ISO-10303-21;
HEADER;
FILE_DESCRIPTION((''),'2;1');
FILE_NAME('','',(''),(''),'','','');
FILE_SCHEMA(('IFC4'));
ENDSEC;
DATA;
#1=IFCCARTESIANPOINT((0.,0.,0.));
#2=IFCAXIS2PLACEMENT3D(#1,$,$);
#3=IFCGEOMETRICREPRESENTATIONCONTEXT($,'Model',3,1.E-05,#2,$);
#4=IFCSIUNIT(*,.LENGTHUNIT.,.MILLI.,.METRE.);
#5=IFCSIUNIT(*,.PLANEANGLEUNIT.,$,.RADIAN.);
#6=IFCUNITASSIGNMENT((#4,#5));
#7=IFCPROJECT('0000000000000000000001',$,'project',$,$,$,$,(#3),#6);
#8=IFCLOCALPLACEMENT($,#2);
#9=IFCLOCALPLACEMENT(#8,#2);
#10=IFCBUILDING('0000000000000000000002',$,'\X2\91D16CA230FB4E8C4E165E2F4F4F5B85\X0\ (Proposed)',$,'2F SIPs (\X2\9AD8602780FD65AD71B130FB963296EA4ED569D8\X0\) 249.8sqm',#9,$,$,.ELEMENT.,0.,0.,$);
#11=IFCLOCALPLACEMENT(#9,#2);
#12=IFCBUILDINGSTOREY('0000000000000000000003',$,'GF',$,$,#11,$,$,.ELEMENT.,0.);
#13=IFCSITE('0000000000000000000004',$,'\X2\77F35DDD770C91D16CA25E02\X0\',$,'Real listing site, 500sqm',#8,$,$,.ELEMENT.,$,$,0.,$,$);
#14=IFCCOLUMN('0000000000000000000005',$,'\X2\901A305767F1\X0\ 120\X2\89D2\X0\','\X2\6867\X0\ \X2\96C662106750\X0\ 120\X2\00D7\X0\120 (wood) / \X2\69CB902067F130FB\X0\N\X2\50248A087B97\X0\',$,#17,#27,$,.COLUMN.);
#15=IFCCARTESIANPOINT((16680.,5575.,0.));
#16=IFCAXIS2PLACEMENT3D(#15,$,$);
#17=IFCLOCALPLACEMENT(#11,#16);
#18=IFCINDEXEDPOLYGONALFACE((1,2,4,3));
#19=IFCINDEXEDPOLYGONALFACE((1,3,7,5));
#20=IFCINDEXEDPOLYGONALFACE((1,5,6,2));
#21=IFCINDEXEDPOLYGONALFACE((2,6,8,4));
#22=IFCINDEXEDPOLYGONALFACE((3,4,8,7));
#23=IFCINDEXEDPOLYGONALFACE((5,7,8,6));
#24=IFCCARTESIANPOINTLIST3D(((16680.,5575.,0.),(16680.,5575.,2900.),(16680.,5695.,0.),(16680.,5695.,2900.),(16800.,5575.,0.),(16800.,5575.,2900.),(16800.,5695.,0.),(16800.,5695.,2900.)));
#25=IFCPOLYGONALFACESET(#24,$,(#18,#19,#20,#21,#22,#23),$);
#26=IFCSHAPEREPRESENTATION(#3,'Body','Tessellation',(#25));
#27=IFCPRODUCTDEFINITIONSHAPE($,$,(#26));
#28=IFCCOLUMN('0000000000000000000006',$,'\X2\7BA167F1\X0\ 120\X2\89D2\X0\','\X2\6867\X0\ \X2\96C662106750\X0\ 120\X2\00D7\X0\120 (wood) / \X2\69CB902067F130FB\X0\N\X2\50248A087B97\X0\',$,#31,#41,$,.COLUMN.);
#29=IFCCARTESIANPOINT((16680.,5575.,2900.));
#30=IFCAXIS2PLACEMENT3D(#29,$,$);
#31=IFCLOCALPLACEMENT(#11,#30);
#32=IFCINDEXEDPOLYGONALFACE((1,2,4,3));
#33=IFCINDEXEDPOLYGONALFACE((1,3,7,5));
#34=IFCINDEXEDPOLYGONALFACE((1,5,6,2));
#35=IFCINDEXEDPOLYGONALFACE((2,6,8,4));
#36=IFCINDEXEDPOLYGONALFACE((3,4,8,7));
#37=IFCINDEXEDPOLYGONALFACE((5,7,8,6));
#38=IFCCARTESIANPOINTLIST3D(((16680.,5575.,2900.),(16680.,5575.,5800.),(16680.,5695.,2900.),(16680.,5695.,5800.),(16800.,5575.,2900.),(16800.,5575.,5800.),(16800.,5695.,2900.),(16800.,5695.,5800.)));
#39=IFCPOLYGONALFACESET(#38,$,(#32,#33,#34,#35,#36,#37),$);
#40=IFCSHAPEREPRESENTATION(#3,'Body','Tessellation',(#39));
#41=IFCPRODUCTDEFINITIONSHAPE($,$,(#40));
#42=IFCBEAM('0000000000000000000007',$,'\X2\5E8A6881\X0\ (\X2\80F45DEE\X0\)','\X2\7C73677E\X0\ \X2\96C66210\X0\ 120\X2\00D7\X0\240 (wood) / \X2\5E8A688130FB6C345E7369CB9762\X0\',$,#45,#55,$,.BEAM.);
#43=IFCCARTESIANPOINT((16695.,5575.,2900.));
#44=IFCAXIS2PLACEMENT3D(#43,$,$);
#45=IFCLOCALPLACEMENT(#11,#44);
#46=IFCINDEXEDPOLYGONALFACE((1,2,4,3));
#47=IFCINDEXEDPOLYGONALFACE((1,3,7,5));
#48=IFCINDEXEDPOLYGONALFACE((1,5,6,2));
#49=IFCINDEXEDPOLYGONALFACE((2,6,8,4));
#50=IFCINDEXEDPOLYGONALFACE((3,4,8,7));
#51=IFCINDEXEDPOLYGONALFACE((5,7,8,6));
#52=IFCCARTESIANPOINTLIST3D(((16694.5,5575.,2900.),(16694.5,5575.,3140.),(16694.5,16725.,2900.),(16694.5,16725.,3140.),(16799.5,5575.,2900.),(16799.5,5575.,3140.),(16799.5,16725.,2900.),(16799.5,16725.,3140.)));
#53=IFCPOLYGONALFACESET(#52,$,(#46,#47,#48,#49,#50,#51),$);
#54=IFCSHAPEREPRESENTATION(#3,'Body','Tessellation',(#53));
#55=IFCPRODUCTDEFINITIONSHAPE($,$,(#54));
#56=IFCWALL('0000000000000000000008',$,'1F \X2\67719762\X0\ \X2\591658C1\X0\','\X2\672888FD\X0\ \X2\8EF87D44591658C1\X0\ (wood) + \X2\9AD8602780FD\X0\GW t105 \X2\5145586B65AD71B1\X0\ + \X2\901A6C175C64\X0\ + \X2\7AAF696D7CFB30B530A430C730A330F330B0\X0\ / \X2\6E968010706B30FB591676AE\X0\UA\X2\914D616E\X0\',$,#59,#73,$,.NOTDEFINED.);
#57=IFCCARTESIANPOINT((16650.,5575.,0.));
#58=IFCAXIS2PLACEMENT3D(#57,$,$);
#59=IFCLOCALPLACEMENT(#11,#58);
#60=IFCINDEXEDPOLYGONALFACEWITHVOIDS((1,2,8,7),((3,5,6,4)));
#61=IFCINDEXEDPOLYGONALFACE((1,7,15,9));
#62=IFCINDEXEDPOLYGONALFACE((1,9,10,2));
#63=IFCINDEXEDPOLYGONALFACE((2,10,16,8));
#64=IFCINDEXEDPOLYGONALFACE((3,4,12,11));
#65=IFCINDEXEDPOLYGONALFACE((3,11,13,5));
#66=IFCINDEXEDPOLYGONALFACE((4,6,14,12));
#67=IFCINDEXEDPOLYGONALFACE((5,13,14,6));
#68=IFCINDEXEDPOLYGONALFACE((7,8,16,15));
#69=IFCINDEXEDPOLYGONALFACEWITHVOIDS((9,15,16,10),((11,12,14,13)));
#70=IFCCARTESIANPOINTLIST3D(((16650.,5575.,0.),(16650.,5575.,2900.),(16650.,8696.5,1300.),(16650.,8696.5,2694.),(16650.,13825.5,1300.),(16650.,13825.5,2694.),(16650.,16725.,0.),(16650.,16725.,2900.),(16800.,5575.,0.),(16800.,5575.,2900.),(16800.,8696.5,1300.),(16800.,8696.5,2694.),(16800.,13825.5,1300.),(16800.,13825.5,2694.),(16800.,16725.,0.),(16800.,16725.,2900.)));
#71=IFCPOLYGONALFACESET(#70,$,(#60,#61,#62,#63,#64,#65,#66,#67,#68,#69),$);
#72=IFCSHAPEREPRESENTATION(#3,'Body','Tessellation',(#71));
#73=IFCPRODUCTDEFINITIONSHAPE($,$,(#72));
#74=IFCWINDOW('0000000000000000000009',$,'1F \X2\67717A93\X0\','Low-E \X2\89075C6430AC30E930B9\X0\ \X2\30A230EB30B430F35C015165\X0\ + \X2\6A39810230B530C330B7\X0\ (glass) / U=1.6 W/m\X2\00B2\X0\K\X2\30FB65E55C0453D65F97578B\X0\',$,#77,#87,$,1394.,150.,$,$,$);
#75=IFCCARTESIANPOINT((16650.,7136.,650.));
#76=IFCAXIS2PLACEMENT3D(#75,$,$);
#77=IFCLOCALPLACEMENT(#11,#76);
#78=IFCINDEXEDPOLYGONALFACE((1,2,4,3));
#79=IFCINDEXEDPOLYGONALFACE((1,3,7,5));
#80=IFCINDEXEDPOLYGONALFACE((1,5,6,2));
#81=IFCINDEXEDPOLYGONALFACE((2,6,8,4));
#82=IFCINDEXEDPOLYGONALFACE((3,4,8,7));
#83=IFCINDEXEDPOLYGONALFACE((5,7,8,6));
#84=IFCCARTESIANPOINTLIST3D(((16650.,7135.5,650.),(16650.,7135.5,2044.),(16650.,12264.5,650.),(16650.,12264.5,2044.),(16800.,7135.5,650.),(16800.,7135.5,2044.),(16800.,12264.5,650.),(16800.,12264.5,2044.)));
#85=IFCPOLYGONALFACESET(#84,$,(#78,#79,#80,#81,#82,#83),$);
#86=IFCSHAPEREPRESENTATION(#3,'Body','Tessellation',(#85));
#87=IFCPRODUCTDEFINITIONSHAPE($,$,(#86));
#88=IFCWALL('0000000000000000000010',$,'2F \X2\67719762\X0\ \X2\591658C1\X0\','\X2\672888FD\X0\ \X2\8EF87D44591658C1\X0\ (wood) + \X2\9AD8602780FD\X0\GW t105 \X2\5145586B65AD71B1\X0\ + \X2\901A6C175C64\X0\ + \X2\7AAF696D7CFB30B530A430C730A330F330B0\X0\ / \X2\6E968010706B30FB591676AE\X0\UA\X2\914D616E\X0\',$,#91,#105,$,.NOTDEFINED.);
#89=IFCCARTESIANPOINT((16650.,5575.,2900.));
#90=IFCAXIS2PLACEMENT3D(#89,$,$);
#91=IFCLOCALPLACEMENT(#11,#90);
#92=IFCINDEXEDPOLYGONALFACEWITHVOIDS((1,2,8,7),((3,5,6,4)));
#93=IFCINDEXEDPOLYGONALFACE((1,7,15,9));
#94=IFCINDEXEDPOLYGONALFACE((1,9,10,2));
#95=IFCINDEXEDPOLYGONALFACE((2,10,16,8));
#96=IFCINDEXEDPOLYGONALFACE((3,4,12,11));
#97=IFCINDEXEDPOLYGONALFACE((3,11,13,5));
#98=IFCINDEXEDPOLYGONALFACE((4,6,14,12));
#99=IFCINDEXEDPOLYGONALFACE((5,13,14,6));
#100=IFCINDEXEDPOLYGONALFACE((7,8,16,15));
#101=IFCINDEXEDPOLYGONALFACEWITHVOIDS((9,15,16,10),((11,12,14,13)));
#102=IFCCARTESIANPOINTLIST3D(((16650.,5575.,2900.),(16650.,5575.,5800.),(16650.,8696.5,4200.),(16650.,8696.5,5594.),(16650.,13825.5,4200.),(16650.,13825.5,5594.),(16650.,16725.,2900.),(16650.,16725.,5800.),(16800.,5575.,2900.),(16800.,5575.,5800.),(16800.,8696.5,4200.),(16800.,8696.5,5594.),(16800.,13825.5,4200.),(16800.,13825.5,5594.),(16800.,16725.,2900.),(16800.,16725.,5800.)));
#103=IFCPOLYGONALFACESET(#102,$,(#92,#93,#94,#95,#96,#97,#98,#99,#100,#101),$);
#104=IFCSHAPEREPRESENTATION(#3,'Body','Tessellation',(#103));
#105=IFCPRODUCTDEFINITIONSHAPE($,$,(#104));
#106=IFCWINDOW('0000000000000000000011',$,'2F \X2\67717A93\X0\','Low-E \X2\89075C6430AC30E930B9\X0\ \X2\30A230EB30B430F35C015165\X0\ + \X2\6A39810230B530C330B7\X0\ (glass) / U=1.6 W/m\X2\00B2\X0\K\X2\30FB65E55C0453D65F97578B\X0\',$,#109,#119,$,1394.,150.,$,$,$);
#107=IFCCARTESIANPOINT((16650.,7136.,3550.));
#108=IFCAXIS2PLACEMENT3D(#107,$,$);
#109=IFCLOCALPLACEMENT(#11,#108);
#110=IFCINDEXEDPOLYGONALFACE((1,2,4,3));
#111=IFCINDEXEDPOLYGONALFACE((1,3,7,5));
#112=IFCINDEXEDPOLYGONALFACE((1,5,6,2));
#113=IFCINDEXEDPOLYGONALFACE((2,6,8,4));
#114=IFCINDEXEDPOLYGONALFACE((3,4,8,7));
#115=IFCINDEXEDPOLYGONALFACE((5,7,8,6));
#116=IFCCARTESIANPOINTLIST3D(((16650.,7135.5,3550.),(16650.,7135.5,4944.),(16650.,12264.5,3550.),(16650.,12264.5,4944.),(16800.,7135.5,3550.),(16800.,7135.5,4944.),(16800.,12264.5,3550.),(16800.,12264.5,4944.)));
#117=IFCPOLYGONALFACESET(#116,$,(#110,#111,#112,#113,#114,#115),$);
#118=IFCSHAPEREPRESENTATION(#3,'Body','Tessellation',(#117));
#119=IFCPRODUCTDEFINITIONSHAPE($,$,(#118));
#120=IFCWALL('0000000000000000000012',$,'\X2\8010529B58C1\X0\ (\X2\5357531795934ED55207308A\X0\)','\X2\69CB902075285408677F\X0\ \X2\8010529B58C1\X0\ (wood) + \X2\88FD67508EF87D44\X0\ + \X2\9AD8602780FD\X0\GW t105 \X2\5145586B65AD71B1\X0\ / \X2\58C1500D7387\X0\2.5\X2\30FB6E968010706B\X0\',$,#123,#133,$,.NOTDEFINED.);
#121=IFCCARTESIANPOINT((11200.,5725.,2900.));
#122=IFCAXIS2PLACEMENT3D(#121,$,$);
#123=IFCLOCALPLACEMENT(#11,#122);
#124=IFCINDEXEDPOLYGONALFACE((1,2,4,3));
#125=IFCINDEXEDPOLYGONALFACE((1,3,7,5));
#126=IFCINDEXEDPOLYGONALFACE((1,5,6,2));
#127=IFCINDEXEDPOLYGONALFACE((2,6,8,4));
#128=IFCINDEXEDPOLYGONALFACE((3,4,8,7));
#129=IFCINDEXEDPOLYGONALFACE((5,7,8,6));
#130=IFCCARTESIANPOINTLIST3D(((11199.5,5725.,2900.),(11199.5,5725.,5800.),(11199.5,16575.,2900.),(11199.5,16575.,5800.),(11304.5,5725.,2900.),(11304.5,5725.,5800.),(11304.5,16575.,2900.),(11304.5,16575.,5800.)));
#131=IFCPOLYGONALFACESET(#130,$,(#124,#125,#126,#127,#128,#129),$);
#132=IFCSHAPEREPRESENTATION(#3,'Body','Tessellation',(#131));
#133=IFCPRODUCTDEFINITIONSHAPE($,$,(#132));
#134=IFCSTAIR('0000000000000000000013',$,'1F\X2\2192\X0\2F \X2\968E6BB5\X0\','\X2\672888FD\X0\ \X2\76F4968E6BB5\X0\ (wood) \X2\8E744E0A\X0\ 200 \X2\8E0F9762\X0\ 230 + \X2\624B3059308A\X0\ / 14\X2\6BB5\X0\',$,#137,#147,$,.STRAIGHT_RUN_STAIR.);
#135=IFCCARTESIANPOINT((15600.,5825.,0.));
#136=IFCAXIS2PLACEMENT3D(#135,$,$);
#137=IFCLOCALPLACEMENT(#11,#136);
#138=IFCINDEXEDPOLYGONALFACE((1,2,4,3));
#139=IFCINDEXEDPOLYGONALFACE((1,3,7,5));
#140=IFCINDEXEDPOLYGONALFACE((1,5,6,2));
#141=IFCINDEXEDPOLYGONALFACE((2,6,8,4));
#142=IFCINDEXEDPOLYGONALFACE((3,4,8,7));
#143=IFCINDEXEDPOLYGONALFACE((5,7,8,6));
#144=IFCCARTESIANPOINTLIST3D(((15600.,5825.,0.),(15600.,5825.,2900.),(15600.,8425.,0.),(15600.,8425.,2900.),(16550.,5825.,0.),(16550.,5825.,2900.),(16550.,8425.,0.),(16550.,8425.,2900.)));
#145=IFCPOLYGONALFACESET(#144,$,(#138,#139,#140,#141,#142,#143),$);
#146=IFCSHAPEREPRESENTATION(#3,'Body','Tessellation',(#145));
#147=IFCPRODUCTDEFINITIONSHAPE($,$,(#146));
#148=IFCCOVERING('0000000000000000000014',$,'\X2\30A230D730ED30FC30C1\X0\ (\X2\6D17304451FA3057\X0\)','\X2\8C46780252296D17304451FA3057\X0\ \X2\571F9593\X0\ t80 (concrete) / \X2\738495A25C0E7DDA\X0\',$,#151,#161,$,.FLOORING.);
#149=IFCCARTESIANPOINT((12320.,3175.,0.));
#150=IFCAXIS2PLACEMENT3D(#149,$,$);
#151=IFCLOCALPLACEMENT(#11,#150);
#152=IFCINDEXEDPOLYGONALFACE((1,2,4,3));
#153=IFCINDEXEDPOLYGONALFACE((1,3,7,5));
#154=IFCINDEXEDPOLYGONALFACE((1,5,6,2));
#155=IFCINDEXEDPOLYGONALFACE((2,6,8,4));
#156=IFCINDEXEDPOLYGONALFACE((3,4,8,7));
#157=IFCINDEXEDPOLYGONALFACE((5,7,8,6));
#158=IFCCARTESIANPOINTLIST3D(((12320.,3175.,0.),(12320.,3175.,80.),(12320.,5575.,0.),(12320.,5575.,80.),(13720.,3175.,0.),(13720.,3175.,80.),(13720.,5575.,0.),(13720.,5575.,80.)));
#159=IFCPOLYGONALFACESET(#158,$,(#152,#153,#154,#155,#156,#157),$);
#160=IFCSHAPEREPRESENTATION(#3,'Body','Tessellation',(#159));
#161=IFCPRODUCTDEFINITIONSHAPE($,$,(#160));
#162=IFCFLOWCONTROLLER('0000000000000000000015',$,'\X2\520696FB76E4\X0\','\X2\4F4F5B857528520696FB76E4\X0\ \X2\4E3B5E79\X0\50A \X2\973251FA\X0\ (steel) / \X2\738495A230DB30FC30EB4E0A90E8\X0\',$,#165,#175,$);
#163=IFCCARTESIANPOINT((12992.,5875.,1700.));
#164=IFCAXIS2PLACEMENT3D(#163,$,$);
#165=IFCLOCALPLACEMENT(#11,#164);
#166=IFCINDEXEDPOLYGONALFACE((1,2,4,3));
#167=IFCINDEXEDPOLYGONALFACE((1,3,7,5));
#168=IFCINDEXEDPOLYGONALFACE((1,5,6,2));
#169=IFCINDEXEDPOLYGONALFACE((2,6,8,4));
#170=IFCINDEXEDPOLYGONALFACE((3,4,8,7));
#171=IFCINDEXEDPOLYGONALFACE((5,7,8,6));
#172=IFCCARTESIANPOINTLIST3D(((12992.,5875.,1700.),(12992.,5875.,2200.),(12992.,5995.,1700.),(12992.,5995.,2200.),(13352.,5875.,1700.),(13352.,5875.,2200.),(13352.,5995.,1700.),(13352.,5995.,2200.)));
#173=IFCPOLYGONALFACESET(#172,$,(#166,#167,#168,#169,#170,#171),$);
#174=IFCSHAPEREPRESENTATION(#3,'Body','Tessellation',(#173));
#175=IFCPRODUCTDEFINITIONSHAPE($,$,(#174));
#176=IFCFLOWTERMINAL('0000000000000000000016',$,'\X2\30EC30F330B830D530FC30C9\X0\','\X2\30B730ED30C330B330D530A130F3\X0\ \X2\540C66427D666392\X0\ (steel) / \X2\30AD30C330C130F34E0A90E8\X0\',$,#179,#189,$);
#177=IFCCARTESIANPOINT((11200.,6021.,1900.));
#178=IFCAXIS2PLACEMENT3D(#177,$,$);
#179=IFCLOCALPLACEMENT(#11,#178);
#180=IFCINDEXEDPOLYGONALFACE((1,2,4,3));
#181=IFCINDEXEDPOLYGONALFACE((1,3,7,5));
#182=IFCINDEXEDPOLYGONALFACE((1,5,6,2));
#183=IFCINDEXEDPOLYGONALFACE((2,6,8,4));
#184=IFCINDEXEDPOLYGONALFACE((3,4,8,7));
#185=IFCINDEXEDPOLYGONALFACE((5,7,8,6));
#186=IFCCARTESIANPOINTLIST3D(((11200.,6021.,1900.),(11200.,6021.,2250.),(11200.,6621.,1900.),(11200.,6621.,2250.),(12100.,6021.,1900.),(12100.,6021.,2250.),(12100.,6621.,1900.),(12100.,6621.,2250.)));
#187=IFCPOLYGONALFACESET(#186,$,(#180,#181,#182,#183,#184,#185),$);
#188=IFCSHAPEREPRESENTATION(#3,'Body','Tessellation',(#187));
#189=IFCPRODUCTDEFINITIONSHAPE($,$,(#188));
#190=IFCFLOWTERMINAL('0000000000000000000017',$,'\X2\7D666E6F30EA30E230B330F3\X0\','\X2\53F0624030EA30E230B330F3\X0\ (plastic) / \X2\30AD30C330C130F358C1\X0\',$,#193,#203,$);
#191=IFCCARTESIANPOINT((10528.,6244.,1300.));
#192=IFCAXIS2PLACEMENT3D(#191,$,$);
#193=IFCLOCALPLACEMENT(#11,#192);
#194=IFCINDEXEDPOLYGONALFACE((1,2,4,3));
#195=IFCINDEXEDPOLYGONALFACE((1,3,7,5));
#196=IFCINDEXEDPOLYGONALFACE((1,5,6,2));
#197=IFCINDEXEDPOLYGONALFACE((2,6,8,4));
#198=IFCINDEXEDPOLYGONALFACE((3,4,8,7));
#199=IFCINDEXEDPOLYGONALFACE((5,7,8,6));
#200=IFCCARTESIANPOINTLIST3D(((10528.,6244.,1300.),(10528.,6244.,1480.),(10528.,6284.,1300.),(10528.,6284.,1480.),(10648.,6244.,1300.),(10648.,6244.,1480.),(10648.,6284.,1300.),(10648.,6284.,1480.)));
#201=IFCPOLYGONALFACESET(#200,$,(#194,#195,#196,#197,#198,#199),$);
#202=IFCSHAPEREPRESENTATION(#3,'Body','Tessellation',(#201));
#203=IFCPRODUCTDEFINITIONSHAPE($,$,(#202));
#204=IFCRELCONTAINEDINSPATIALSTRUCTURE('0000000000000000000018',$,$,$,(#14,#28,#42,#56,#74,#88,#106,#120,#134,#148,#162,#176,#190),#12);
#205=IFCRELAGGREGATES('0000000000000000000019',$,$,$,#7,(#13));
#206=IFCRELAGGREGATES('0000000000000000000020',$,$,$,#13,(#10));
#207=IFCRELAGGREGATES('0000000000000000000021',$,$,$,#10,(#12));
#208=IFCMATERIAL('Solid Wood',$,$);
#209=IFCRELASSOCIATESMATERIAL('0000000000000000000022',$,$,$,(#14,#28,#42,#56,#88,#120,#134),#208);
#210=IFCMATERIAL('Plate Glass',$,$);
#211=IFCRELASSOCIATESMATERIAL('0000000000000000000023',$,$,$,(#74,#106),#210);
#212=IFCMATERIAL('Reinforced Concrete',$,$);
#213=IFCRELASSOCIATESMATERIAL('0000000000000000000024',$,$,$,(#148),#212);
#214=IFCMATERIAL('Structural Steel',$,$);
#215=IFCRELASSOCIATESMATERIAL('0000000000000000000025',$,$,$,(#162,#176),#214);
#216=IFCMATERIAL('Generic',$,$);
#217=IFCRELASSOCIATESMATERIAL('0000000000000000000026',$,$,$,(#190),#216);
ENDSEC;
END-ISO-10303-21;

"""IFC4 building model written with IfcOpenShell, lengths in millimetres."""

from ifc_helpers import new_model, si_unit, frame, frame_2d, origin, place, context, project, spatial, rectangle, extrude, material, element, fill, save


model = new_model("IFC4")

# Units and contexts
model_context = context("Model", 3, precision=1e-05, world=origin())
ifc_project = project(units=[si_unit("LENGTHUNIT", "METRE", prefix="MILLI"), si_unit("PLANEANGLEUNIT", "RADIAN")], contexts=[model_context])

# Site, building, storey
site_placement = place(None, origin())
site = spatial("IfcSite", under=ifc_project, at=site_placement, Name="石川県金沢市", ObjectType="Real listing site, 500sqm", CompositionType="ELEMENT", RefElevation=0.0)
building_placement = place(site_placement, origin())
building = spatial("IfcBuilding", under=site, at=building_placement, Name="金沢・二世帯住宅 (Proposed)", ObjectType="2F SIPs (高性能断熱・防雪仕様) 249.8sqm", CompositionType="ELEMENT", ElevationOfRefHeight=0.0, ElevationOfTerrain=0.0)
storey_placement = place(building_placement, origin())
storey = spatial("IfcBuildingStorey", under=building, at=storey_placement, Name="GF", CompositionType="ELEMENT", Elevation=0.0)

# Columns
ifc_material_1 = material(Name="Solid Wood")
column_1_placement = place(storey_placement, frame((16680.0, 5575.0, 0.0)))
element("IfcColumn", 1, at=column_1_placement, inside=storey, material=ifc_material_1, Name="通し柱 120角", Description="桧 集成材 120×120 (wood) / 構造柱・N値計算", PredefinedType="COLUMN", context=model_context, shape_type="SweptSolid", body=[
    extrude(rectangle(XDim=120.0, YDim=120.0, at=frame_2d((60.0, 60.0))), frame((16680.0, 5575.0, 0.0)), (0.0, 0.0, 1.0), 2900.0),
])
column_2_placement = place(storey_placement, frame((16680.0, 5575.0, 2900.0)))
element("IfcColumn", 2, at=column_2_placement, inside=storey, material=ifc_material_1, Name="管柱 120角", Description="桧 集成材 120×120 (wood) / 構造柱・N値計算", PredefinedType="COLUMN", context=model_context, shape_type="SweptSolid", body=[
    extrude(rectangle(XDim=120.0, YDim=120.0, at=frame_2d((60.0, 60.0))), frame((16680.0, 5575.0, 2900.0)), (0.0, 0.0, 1.0), 2900.0),
])

# Beam
beam_1_placement = place(storey_placement, frame((16695.0, 5575.0, 2900.0)))
element("IfcBeam", 3, at=beam_1_placement, inside=storey, material=ifc_material_1, Name="床梁 (胴差)", Description="米松 集成 120×240 (wood) / 床梁・水平構面", PredefinedType="BEAM", context=model_context, shape_type="SweptSolid", body=[
    extrude(rectangle(XDim=105.0, YDim=11150.0, at=frame_2d((52.0, 5575.0))), frame((16695.0, 5575.0, 2900.0)), (0.0, 0.0, 1.0), 240.0),
])

# Wall, opening, window
wall_1_placement = place(storey_placement, frame((16650.0, 5575.0, 0.0)))
wall_1 = element("IfcWall", 4, at=wall_1_placement, inside=storey, material=ifc_material_1, Name="1F 東面 外壁", Description="木製 軸組外壁 (wood) + 高性能GW t105 充填断熱 + 通気層 + 窯業系サイディング / 準耐火・外皮UA配慮", PredefinedType="NOTDEFINED", context=model_context, shape_type="SweptSolid", body=[
    extrude(rectangle(XDim=150.0, YDim=11150.0, at=frame_2d((75.0, 5575.0))), frame((16650.0, 5575.0, 0.0)), (0.0, 0.0, 1.0), 2900.0),
])
opening_1_placement = place(storey_placement, frame((16650.0, 7136.0, 650.0)))
opening_1 = element("IfcOpeningElement", 5, at=opening_1_placement, cuts=wall_1, PredefinedType="NOTDEFINED", context=model_context, shape_type="SweptSolid", body=[
    extrude(rectangle(XDim=150.0, YDim=5129.0, at=frame_2d((75.0, 2564.0))), frame((16650.0, 7136.0, 650.0)), (0.0, 0.0, 1.0), 1394.0),
])
ifc_material_2 = material(Name="Plate Glass")
window_1_placement = place(storey_placement, frame((16650.0, 7136.0, 650.0)))
window_1 = element("IfcWindow", 6, at=window_1_placement, inside=storey, material=ifc_material_2, Name="1F 東窓", Description="Low-E 複層ガラス アルゴン封入 + 樹脂サッシ (glass) / U=1.6 W/m²K・日射取得型", OverallHeight=1394.0, OverallWidth=150.0, context=model_context, shape_type="SweptSolid", body=[
    extrude(rectangle(XDim=150.0, YDim=5129.0, at=frame_2d((75.0, 2564.0))), frame((16650.0, 7136.0, 650.0)), (0.0, 0.0, 1.0), 1394.0),
])
fill(opening_1, window_1)

# Wall, opening, window
wall_2_placement = place(storey_placement, frame((16650.0, 5575.0, 2900.0)))
wall_2 = element("IfcWall", 7, at=wall_2_placement, inside=storey, material=ifc_material_1, Name="2F 東面 外壁", Description="木製 軸組外壁 (wood) + 高性能GW t105 充填断熱 + 通気層 + 窯業系サイディング / 準耐火・外皮UA配慮", PredefinedType="NOTDEFINED", context=model_context, shape_type="SweptSolid", body=[
    extrude(rectangle(XDim=150.0, YDim=11150.0, at=frame_2d((75.0, 5575.0))), frame((16650.0, 5575.0, 2900.0)), (0.0, 0.0, 1.0), 2900.0),
])
opening_2_placement = place(storey_placement, frame((16650.0, 7136.0, 3550.0)))
opening_2 = element("IfcOpeningElement", 8, at=opening_2_placement, cuts=wall_2, PredefinedType="NOTDEFINED", context=model_context, shape_type="SweptSolid", body=[
    extrude(rectangle(XDim=150.0, YDim=5129.0, at=frame_2d((75.0, 2564.0))), frame((16650.0, 7136.0, 3550.0)), (0.0, 0.0, 1.0), 1394.0),
])
window_2_placement = place(storey_placement, frame((16650.0, 7136.0, 3550.0)))
window_2 = element("IfcWindow", 9, at=window_2_placement, inside=storey, material=ifc_material_2, Name="2F 東窓", Description="Low-E 複層ガラス アルゴン封入 + 樹脂サッシ (glass) / U=1.6 W/m²K・日射取得型", OverallHeight=1394.0, OverallWidth=150.0, context=model_context, shape_type="SweptSolid", body=[
    extrude(rectangle(XDim=150.0, YDim=5129.0, at=frame_2d((75.0, 2564.0))), frame((16650.0, 7136.0, 3550.0)), (0.0, 0.0, 1.0), 1394.0),
])
fill(opening_2, window_2)

# Wall
wall_3_placement = place(storey_placement, frame((11200.0, 5725.0, 2900.0)))
element("IfcWall", 10, at=wall_3_placement, inside=storey, material=ifc_material_1, Name="耐力壁 (南北間仕切り)", Description="構造用合板 耐力壁 (wood) + 製材軸組 + 高性能GW t105 充填断熱 / 壁倍率2.5・準耐火", PredefinedType="NOTDEFINED", context=model_context, shape_type="SweptSolid", body=[
    extrude(rectangle(XDim=105.0, YDim=10850.0, at=frame_2d((52.0, 5425.0))), frame((11200.0, 5725.0, 2900.0)), (0.0, 0.0, 1.0), 2900.0),
])

# Stair
stair_placement = place(storey_placement, frame((15600.0, 5825.0, 0.0)))
element("IfcStair", 11, at=stair_placement, inside=storey, material=ifc_material_1, Name="1F→2F 階段", Description="木製 直階段 (wood) 蹴上 200 踏面 230 + 手すり / 14段", PredefinedType="STRAIGHT_RUN_STAIR", context=model_context, shape_type="SweptSolid", body=[
    extrude(rectangle(XDim=950.0, YDim=2600.0, at=frame_2d((475.0, 1300.0))), frame((15600.0, 5825.0, 0.0)), (0.0, 0.0, 1.0), 2900.0),
])

# Covering
ifc_material_3 = material(Name="Reinforced Concrete")
covering_placement = place(storey_placement, frame((12320.0, 3175.0, 0.0)))
element("IfcCovering", 12, at=covering_placement, inside=storey, material=ifc_material_3, Name="アプローチ (洗い出し)", Description="豆砂利洗い出し 土間 t80 (concrete) / 玄関導線", PredefinedType="FLOORING", context=model_context, shape_type="SweptSolid", body=[
    extrude(rectangle(XDim=1400.0, YDim=2400.0, at=frame_2d((700.0, 1200.0))), frame((12320.0, 3175.0, 0.0)), (0.0, 0.0, 1.0), 80.0),
])

# Flow controller
ifc_material_4 = material(Name="Structural Steel")
flow_controller_placement = place(storey_placement, frame((12992.0, 5875.0, 1700.0)))
element("IfcFlowController", 13, at=flow_controller_placement, inside=storey, material=ifc_material_4, Name="分電盤", Description="住宅用分電盤 主幹50A 露出 (steel) / 玄関ホール上部", context=model_context, shape_type="SweptSolid", body=[
    extrude(rectangle(XDim=360.0, YDim=120.0, at=frame_2d((180.0, 60.0))), frame((12992.0, 5875.0, 1700.0)), (0.0, 0.0, 1.0), 500.0),
])

# Flow terminals
flow_terminal_1_placement = place(storey_placement, frame((11200.0, 6021.0, 1900.0)))
element("IfcFlowTerminal", 14, at=flow_terminal_1_placement, inside=storey, material=ifc_material_4, Name="レンジフード", Description="シロッコファン 同時給排 (steel) / キッチン上部", context=model_context, shape_type="SweptSolid", body=[
    extrude(rectangle(XDim=900.0, YDim=600.0, at=frame_2d((450.0, 300.0))), frame((11200.0, 6021.0, 1900.0)), (0.0, 0.0, 1.0), 350.0),
])
ifc_material_5 = material(Name="Generic")
flow_terminal_2_placement = place(storey_placement, frame((10528.0, 6244.0, 1300.0)))
element("IfcFlowTerminal", 15, at=flow_terminal_2_placement, inside=storey, material=ifc_material_5, Name="給湯リモコン", Description="台所リモコン (plastic) / キッチン壁", context=model_context, shape_type="SweptSolid", body=[
    extrude(rectangle(XDim=120.0, YDim=40.0, at=frame_2d((60.0, 20.0))), frame((10528.0, 6244.0, 1300.0)), (0.0, 0.0, 1.0), 180.0),
])

save(model, "model.ifc")
